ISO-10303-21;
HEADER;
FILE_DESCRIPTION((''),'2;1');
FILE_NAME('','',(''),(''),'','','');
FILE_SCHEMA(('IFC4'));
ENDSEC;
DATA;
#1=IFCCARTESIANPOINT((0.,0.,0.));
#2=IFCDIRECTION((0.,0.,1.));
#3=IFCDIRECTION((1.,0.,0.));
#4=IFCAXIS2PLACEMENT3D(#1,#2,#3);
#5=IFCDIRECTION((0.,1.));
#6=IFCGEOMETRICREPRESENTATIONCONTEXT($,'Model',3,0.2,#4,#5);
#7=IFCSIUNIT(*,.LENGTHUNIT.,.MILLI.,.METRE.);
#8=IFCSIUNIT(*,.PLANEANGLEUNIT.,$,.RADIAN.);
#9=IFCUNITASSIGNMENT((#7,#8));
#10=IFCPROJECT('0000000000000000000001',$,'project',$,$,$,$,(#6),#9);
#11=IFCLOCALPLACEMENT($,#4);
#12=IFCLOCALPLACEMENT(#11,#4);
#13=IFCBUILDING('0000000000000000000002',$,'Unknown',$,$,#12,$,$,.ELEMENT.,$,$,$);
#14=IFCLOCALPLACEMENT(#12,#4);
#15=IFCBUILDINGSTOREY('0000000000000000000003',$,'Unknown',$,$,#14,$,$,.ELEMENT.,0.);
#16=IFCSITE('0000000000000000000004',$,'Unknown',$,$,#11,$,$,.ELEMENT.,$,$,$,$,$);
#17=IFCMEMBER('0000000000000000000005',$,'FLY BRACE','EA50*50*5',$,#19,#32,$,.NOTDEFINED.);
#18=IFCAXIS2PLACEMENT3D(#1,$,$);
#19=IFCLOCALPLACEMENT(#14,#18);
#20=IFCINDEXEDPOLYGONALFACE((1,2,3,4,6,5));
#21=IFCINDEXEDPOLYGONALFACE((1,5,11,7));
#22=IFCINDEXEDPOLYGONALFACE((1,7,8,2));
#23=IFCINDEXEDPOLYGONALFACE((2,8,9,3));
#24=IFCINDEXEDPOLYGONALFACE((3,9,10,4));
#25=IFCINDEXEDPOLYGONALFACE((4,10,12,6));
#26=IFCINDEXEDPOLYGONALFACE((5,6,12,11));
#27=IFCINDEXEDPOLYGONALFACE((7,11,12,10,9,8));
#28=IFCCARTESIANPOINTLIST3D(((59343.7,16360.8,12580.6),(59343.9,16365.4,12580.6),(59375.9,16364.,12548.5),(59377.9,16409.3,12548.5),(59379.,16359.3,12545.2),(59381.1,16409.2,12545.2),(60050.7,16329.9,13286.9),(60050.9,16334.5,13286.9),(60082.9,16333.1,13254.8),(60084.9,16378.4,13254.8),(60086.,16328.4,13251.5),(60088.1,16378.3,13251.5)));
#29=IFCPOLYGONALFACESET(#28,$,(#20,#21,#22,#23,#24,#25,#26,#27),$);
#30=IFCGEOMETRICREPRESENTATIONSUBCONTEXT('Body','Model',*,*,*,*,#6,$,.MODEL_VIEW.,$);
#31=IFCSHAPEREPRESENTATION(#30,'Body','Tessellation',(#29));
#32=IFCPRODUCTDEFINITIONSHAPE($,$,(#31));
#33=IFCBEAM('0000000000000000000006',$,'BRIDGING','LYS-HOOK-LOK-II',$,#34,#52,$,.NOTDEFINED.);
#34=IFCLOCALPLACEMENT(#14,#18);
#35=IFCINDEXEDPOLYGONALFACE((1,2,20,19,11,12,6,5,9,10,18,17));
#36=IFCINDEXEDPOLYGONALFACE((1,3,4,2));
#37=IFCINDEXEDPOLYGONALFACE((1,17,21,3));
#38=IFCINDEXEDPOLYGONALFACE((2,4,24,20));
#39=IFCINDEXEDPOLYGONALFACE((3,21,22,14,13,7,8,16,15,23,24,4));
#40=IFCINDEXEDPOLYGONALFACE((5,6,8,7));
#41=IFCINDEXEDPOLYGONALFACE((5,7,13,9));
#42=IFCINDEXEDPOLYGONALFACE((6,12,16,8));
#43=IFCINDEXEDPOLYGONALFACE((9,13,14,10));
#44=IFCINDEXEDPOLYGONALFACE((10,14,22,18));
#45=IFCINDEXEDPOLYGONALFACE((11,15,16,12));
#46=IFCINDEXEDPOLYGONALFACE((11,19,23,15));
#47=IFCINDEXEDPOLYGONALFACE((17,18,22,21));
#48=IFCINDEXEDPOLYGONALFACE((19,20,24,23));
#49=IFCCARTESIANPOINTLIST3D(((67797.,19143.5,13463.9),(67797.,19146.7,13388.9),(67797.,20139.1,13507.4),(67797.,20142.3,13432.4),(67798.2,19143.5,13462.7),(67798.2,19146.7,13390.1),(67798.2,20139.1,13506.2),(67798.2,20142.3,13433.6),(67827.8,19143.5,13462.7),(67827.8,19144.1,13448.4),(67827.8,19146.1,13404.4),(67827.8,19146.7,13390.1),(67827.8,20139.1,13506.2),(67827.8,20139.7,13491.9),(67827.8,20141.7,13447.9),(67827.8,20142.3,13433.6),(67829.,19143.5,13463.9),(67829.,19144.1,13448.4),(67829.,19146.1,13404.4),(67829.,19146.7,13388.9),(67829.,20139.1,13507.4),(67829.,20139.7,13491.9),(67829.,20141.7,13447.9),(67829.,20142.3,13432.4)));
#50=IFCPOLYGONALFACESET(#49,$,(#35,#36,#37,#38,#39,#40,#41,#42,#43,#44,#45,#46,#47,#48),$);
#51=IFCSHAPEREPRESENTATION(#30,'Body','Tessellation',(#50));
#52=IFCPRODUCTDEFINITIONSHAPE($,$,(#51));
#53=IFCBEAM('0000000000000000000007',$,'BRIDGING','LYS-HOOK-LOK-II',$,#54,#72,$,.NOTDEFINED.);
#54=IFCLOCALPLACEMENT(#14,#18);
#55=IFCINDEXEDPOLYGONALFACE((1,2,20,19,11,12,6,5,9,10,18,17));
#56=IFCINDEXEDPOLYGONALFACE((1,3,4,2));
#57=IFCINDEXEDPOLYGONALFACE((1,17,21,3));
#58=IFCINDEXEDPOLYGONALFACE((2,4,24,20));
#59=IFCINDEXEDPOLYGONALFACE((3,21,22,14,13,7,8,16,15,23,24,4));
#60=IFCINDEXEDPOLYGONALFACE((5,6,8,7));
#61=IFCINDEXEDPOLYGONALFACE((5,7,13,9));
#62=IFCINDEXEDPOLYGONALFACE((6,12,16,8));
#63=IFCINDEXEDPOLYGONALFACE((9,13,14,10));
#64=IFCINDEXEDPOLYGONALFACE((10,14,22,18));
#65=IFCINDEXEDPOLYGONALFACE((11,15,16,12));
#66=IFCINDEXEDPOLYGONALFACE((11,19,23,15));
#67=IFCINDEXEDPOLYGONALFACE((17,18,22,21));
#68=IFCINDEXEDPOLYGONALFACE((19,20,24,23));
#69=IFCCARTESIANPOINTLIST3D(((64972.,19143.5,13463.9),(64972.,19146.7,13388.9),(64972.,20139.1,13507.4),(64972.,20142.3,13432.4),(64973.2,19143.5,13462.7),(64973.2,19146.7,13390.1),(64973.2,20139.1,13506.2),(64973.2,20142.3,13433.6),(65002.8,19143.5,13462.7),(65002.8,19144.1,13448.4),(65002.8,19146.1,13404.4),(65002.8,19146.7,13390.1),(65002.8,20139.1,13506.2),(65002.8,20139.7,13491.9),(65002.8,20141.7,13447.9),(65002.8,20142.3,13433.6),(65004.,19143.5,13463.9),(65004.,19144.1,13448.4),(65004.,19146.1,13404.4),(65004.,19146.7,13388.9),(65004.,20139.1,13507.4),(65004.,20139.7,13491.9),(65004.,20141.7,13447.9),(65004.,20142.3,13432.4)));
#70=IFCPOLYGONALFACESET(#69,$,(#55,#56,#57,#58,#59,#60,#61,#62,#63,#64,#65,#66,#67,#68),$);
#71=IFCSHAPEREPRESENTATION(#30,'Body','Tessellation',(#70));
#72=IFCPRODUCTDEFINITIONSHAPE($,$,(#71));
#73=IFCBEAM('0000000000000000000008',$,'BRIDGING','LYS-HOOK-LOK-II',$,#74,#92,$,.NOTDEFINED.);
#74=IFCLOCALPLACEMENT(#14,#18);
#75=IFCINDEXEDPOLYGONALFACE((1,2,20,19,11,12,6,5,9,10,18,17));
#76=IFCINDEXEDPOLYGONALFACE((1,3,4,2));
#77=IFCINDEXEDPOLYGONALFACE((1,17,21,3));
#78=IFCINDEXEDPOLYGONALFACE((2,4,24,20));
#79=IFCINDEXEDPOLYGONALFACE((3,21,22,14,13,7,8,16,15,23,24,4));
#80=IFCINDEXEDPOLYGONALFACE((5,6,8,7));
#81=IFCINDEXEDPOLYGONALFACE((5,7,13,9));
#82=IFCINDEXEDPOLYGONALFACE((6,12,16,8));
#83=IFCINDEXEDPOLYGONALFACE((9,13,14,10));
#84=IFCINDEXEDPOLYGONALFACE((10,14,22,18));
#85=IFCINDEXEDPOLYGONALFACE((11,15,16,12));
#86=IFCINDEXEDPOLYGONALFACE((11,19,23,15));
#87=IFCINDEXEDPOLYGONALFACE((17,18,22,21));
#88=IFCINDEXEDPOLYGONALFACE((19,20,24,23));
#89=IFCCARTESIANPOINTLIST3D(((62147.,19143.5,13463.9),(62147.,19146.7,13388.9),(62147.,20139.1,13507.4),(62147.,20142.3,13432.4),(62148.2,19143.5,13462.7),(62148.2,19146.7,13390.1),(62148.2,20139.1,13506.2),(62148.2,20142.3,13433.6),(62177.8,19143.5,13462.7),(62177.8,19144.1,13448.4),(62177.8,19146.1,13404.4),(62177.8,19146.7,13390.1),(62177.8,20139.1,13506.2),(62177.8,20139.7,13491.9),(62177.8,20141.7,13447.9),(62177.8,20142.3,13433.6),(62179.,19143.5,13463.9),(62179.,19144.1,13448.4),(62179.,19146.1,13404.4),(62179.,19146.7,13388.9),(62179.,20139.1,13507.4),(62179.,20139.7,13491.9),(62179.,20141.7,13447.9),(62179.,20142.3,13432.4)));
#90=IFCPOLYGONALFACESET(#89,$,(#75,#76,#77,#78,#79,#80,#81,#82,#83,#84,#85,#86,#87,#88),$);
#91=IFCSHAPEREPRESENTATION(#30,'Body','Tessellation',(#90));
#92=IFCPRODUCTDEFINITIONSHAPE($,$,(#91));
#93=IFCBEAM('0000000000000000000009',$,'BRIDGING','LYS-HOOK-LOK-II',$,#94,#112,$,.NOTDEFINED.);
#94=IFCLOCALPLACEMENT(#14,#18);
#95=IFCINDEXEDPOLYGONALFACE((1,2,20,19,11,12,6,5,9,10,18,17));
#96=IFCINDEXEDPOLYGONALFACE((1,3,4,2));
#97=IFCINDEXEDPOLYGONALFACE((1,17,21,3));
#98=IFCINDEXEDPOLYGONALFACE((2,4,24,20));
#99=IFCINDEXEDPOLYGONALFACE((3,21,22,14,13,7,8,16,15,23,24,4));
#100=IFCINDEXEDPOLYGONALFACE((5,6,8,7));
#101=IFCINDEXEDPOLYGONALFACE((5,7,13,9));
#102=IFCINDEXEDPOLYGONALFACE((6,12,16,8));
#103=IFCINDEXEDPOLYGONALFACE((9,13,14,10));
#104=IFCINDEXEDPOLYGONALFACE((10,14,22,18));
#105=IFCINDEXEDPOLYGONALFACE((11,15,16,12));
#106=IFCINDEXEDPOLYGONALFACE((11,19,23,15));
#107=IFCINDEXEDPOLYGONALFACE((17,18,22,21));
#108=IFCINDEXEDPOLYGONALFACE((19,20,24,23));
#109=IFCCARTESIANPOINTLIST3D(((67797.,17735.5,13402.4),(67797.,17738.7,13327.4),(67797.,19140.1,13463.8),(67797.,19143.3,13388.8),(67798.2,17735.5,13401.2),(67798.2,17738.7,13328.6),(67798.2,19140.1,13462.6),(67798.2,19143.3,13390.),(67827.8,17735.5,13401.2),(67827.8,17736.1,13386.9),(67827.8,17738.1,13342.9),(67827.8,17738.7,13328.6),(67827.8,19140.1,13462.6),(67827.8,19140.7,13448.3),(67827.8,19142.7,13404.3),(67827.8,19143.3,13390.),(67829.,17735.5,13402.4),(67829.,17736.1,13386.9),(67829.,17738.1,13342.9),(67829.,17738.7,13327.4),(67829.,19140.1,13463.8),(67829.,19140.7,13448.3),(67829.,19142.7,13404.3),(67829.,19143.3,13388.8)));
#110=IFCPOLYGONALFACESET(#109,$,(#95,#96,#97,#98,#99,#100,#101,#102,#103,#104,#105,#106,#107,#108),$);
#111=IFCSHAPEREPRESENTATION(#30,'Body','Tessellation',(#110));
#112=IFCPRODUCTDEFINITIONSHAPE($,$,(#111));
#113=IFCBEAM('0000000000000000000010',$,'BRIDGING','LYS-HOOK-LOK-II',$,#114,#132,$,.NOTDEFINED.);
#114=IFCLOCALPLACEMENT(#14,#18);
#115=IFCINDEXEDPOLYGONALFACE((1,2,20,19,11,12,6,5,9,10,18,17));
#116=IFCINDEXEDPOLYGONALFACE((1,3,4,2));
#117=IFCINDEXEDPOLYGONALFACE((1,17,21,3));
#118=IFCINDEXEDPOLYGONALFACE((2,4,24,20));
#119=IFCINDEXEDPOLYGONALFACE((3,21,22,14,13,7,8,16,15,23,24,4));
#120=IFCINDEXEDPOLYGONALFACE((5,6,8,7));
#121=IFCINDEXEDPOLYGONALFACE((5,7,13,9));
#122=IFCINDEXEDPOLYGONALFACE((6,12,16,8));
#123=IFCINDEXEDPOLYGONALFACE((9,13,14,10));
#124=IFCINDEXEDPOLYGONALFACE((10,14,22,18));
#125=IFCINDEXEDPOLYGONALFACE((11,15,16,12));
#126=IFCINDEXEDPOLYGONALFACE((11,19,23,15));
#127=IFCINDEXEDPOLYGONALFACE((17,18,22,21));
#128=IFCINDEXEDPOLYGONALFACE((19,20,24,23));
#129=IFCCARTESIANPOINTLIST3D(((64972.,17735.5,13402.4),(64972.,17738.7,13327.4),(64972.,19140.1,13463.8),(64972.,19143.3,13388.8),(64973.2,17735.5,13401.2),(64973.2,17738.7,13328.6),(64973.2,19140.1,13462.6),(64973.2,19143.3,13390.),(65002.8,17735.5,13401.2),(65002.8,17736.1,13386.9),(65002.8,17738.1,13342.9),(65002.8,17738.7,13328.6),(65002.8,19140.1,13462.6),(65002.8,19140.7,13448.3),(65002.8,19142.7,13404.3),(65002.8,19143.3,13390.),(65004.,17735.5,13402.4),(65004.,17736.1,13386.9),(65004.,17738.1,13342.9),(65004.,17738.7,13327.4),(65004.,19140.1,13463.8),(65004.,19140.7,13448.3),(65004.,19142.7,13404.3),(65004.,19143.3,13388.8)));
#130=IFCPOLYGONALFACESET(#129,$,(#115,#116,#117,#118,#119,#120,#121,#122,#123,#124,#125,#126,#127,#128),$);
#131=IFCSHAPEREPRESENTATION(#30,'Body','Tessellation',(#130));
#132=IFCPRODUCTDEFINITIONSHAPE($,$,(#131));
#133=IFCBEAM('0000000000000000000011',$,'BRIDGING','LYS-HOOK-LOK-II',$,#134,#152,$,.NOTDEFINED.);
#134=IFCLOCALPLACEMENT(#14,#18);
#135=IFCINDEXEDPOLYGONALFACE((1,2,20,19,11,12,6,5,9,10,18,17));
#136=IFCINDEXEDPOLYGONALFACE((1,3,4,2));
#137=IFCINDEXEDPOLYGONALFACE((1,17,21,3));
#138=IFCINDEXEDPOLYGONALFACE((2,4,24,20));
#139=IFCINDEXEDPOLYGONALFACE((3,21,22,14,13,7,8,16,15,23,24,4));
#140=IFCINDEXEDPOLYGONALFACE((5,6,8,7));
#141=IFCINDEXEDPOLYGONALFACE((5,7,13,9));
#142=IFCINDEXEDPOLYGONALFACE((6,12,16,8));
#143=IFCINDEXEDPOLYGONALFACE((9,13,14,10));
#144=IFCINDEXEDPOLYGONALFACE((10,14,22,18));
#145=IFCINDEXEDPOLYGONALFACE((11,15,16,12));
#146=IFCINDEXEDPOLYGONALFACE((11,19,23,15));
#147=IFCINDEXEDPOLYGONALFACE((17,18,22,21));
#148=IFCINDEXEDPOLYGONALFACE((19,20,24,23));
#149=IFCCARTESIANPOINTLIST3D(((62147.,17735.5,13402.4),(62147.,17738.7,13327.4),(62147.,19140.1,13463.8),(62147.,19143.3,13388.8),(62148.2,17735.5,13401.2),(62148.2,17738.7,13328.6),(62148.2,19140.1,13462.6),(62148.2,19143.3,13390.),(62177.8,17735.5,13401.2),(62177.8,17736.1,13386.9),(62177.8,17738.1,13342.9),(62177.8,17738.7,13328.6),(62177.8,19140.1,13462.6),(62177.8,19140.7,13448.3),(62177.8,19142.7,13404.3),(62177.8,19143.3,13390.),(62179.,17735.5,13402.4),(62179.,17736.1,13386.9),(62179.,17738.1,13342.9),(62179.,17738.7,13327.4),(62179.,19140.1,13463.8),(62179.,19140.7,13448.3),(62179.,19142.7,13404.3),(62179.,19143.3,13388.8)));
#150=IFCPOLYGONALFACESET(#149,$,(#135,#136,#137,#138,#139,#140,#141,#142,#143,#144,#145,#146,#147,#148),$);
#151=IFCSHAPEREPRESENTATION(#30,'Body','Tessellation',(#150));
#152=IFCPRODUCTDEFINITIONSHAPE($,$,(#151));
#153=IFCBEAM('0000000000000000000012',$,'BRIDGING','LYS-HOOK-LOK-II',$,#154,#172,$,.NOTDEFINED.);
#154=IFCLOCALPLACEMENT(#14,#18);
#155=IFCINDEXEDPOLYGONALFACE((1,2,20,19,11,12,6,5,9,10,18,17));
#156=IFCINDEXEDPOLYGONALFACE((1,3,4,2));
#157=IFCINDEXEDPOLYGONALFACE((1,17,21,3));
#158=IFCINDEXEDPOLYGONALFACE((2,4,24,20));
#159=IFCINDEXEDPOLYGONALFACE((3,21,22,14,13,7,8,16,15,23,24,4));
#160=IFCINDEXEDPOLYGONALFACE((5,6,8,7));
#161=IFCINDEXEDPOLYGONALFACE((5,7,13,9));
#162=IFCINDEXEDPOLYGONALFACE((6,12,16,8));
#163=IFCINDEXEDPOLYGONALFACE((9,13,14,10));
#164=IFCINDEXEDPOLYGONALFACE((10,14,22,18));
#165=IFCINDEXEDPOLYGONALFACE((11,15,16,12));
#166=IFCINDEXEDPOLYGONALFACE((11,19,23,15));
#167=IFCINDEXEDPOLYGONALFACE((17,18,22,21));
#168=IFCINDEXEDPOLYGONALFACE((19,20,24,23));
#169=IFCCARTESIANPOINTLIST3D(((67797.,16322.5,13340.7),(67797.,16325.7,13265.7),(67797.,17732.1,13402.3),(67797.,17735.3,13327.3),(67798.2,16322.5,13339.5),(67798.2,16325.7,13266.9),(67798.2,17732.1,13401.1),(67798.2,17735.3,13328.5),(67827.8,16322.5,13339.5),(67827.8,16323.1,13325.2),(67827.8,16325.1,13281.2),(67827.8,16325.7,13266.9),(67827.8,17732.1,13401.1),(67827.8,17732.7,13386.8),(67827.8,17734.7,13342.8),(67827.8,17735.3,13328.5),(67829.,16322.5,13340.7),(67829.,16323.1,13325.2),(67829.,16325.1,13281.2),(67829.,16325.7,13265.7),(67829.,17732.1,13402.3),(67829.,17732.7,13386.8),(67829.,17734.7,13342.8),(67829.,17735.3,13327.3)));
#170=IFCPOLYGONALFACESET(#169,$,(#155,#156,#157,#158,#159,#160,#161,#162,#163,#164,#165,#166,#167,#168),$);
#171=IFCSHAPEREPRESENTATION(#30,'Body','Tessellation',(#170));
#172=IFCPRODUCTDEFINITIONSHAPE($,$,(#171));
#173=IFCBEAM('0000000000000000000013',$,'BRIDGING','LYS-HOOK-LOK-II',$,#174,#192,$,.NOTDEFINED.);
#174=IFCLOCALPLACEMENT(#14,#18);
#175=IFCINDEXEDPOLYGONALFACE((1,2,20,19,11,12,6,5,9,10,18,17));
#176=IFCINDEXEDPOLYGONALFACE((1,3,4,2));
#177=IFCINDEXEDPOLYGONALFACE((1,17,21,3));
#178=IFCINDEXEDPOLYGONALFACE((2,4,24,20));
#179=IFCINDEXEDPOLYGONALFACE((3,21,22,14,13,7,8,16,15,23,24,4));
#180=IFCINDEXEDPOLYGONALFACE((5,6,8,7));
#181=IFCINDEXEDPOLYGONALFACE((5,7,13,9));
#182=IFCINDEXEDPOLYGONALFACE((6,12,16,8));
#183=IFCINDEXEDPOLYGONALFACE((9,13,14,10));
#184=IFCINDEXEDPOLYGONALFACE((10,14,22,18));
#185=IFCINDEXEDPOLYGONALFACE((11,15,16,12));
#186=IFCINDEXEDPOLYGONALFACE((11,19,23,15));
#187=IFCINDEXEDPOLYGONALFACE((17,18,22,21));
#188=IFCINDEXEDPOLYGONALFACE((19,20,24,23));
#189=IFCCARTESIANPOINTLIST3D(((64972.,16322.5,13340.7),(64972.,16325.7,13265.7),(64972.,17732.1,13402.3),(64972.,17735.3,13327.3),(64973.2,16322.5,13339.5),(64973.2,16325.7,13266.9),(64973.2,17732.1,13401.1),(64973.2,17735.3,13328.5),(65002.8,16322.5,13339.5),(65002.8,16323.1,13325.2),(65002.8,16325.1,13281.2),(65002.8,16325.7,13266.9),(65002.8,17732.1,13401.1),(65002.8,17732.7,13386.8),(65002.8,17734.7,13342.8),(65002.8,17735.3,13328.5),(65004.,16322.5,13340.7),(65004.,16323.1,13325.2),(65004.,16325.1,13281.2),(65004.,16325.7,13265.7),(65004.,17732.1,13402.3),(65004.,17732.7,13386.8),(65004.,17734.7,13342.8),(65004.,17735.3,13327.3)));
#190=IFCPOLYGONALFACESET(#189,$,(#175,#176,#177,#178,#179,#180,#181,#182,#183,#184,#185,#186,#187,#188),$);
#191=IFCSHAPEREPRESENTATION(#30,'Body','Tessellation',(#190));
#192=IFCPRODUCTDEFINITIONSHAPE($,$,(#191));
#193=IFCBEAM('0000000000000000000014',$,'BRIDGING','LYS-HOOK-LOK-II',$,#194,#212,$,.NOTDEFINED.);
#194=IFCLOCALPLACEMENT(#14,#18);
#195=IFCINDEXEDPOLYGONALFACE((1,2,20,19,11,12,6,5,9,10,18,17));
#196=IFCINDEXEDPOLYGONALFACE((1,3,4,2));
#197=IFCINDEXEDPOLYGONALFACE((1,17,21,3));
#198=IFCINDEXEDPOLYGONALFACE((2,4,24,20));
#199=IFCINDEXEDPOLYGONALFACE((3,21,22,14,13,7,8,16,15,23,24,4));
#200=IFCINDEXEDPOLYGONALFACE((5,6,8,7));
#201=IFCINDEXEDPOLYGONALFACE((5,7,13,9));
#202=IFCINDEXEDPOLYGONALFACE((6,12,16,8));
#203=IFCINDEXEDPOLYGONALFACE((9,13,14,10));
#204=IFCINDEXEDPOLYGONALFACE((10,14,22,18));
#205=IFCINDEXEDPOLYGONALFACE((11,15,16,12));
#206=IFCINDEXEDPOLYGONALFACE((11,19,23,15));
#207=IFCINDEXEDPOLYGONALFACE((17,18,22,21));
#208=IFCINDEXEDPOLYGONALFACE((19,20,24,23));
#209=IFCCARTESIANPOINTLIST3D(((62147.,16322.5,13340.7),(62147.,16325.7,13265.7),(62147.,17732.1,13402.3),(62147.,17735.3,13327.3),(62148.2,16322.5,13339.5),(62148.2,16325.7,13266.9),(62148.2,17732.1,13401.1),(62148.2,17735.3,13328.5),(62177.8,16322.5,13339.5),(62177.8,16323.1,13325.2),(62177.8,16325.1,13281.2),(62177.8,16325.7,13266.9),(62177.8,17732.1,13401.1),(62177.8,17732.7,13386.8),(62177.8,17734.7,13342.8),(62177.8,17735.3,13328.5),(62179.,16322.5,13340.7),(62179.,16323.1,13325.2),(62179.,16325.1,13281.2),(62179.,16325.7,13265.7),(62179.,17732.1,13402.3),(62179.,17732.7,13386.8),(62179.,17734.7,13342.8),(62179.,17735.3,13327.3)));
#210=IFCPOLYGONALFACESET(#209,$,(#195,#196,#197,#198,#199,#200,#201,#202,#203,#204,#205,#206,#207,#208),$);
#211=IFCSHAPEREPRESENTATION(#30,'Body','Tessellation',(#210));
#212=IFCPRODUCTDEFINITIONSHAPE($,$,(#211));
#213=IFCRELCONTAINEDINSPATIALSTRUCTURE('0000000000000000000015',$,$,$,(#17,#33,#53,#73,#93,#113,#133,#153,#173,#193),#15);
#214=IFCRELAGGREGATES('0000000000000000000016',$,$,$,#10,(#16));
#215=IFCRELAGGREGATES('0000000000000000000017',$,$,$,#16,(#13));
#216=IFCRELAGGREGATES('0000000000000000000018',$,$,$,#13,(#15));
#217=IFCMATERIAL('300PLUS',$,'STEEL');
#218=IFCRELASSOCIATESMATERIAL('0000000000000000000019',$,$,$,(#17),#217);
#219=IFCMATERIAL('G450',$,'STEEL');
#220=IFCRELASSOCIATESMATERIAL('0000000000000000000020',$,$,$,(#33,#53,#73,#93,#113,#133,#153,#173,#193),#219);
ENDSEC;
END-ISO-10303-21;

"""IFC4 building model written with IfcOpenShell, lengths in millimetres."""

from ifc_helpers import new_model, si_unit, direction, frame, origin_with_axes, place, context, subcontext, project, spatial, line, indexed_curve, outline, extrude, material, element, save


model = new_model("IFC4")

# Units and contexts
model_context = context("Model", 3, precision=0.2, world=origin_with_axes(), true_north=direction((0.0, 1.0)))
body_context = subcontext(model_context, "Body", "Model", "MODEL_VIEW")
ifc_project = project(units=[si_unit("LENGTHUNIT", "METRE", prefix="MILLI"), si_unit("PLANEANGLEUNIT", "RADIAN")], contexts=[model_context])

# Site, building, storey
site_placement = place(None, origin_with_axes())
site = spatial("IfcSite", under=ifc_project, at=site_placement, Name="Unknown", CompositionType="ELEMENT")
building_placement = place(site_placement, origin_with_axes())
building = spatial("IfcBuilding", under=site, at=building_placement, Name="Unknown", CompositionType="ELEMENT")
storey_placement = place(building_placement, origin_with_axes())
storey = spatial("IfcBuildingStorey", under=building, at=storey_placement, Name="Unknown", CompositionType="ELEMENT", Elevation=0.0)

# Member
ifc_material_1 = material(Name="300PLUS", Category="STEEL")
member_placement = place(storey_placement, frame((59362.4, 16385.0, 12562.9), z_axis=(-0.705745, 0.030845, 0.707794), x_axis=(0.707119, -0.030905, 0.706419)))
element("IfcMember", 1, at=member_placement, inside=storey, material=ifc_material_1, Name="FLY BRACE", Description="EA50*50*5", PredefinedType="NOTDEFINED", context=body_context, shape_type="SolidModel", body=[
    extrude(outline(indexed_curve([(-25.0, -25.0), (25.0, -25.0), (25.0, -20.4), (-20.4, -20.4), (-20.4, 25.0), (-25.0, 25.0)], segments=[line(1, 2, 3, 4, 5, 6, 1)])), frame((0.0, 0.0, 0.0), z_axis=(-1.0, 0.0, 0.0), x_axis=(0.0, 0.0, 1.0)), (0.0, 0.0, -1.0), 999.8),
])

# Beams
ifc_material_2 = material(Name="G450", Category="STEEL")
for number, where, z_axis, x_axis, name in (
    (2, (67813.0, 19145.1, 13426.4), (1.0, 0.0, 0.0), (0.0, 0.999047, 0.043651), "BRIDGING"),
    (3, (64988.0, 19145.1, 13426.4), (1.0, 0.0, 0.0), (0.0, 0.999047, 0.043651), "BRIDGING"),
    (4, (62163.0, 19145.1, 13426.4), (1.0, 0.0, 0.0), (0.0, 0.999047, 0.043651), "BRIDGING"),
):
    element("IfcBeam", number, at=place(storey_placement, frame(where, z_axis=z_axis, x_axis=x_axis)), inside=storey, material=ifc_material_2, Name=name, Description="LYS-HOOK-LOK-II", PredefinedType="NOTDEFINED", context=body_context, shape_type="SolidModel", body=[
        extrude(outline(indexed_curve([(16.0, -37.5), (16.0, -22.0), (14.8, -22.0), (14.8, -36.3), (-14.8, -36.3), (-14.8, 36.3), (14.8, 36.3), (14.8, 22.0), (16.0, 22.0), (16.0, 37.5), (-16.0, 37.5), (-16.0, -37.5)], segments=[line(1, 2, 3, 4, 5, 6, 7, 8, 9, 10, 11, 12, 1)])), frame((0.0, 0.0, 0.0), z_axis=(-1.0, 0.0, 0.0), x_axis=(0.0, 0.0, 1.0)), (0.0, 0.0, -1.0), 996.5),
    ])
for number, where, z_axis, x_axis, name in (
    (5, (67813.0, 17737.1, 13364.9), (1.0, 0.0, 0.0), (0.0, 0.999046, 0.043672), "BRIDGING"),
    (6, (64988.0, 17737.1, 13364.9), (1.0, 0.0, 0.0), (0.0, 0.999046, 0.043672), "BRIDGING"),
    (7, (62163.0, 17737.1, 13364.9), (1.0, 0.0, 0.0), (0.0, 0.999046, 0.043672), "BRIDGING"),
):
    element("IfcBeam", number, at=place(storey_placement, frame(where, z_axis=z_axis, x_axis=x_axis)), inside=storey, material=ifc_material_2, Name=name, Description="LYS-HOOK-LOK-II", PredefinedType="NOTDEFINED", context=body_context, shape_type="SolidModel", body=[
        extrude(outline(indexed_curve([(16.0, -37.5), (16.0, -22.0), (14.8, -22.0), (14.8, -36.3), (-14.8, -36.3), (-14.8, 36.3), (14.8, 36.3), (14.8, 22.0), (16.0, 22.0), (16.0, 37.5), (-16.0, 37.5), (-16.0, -37.5)], segments=[line(1, 2, 3, 4, 5, 6, 7, 8, 9, 10, 11, 12, 1)])), frame((0.0, 0.0, 0.0), z_axis=(-1.0, 0.0, 0.0), x_axis=(0.0, 0.0, 1.0)), (0.0, 0.0, -1.0), 1405.9),
    ])
for number, where, z_axis, x_axis, name in (
    (8, (67813.0, 16324.1, 13303.2), (1.0, 0.0, 0.0), (0.0, 0.999047, 0.043659), "BRIDGING"),
    (9, (64988.0, 16324.1, 13303.2), (1.0, 0.0, 0.0), (0.0, 0.999047, 0.043659), "BRIDGING"),
    (10, (62163.0, 16324.1, 13303.2), (1.0, 0.0, 0.0), (0.0, 0.999047, 0.043659), "BRIDGING"),
):
    element("IfcBeam", number, at=place(storey_placement, frame(where, z_axis=z_axis, x_axis=x_axis)), inside=storey, material=ifc_material_2, Name=name, Description="LYS-HOOK-LOK-II", PredefinedType="NOTDEFINED", context=body_context, shape_type="SolidModel", body=[
        extrude(outline(indexed_curve([(16.0, -37.5), (16.0, -22.0), (14.8, -22.0), (14.8, -36.3), (-14.8, -36.3), (-14.8, 36.3), (14.8, 36.3), (14.8, 22.0), (16.0, 22.0), (16.0, 37.5), (-16.0, 37.5), (-16.0, -37.5)], segments=[line(1, 2, 3, 4, 5, 6, 7, 8, 9, 10, 11, 12, 1)])), frame((0.0, 0.0, 0.0), z_axis=(-1.0, 0.0, 0.0), x_axis=(0.0, 0.0, 1.0)), (0.0, 0.0, -1.0), 1410.9),
    ])

save(model, "model.ifc")
